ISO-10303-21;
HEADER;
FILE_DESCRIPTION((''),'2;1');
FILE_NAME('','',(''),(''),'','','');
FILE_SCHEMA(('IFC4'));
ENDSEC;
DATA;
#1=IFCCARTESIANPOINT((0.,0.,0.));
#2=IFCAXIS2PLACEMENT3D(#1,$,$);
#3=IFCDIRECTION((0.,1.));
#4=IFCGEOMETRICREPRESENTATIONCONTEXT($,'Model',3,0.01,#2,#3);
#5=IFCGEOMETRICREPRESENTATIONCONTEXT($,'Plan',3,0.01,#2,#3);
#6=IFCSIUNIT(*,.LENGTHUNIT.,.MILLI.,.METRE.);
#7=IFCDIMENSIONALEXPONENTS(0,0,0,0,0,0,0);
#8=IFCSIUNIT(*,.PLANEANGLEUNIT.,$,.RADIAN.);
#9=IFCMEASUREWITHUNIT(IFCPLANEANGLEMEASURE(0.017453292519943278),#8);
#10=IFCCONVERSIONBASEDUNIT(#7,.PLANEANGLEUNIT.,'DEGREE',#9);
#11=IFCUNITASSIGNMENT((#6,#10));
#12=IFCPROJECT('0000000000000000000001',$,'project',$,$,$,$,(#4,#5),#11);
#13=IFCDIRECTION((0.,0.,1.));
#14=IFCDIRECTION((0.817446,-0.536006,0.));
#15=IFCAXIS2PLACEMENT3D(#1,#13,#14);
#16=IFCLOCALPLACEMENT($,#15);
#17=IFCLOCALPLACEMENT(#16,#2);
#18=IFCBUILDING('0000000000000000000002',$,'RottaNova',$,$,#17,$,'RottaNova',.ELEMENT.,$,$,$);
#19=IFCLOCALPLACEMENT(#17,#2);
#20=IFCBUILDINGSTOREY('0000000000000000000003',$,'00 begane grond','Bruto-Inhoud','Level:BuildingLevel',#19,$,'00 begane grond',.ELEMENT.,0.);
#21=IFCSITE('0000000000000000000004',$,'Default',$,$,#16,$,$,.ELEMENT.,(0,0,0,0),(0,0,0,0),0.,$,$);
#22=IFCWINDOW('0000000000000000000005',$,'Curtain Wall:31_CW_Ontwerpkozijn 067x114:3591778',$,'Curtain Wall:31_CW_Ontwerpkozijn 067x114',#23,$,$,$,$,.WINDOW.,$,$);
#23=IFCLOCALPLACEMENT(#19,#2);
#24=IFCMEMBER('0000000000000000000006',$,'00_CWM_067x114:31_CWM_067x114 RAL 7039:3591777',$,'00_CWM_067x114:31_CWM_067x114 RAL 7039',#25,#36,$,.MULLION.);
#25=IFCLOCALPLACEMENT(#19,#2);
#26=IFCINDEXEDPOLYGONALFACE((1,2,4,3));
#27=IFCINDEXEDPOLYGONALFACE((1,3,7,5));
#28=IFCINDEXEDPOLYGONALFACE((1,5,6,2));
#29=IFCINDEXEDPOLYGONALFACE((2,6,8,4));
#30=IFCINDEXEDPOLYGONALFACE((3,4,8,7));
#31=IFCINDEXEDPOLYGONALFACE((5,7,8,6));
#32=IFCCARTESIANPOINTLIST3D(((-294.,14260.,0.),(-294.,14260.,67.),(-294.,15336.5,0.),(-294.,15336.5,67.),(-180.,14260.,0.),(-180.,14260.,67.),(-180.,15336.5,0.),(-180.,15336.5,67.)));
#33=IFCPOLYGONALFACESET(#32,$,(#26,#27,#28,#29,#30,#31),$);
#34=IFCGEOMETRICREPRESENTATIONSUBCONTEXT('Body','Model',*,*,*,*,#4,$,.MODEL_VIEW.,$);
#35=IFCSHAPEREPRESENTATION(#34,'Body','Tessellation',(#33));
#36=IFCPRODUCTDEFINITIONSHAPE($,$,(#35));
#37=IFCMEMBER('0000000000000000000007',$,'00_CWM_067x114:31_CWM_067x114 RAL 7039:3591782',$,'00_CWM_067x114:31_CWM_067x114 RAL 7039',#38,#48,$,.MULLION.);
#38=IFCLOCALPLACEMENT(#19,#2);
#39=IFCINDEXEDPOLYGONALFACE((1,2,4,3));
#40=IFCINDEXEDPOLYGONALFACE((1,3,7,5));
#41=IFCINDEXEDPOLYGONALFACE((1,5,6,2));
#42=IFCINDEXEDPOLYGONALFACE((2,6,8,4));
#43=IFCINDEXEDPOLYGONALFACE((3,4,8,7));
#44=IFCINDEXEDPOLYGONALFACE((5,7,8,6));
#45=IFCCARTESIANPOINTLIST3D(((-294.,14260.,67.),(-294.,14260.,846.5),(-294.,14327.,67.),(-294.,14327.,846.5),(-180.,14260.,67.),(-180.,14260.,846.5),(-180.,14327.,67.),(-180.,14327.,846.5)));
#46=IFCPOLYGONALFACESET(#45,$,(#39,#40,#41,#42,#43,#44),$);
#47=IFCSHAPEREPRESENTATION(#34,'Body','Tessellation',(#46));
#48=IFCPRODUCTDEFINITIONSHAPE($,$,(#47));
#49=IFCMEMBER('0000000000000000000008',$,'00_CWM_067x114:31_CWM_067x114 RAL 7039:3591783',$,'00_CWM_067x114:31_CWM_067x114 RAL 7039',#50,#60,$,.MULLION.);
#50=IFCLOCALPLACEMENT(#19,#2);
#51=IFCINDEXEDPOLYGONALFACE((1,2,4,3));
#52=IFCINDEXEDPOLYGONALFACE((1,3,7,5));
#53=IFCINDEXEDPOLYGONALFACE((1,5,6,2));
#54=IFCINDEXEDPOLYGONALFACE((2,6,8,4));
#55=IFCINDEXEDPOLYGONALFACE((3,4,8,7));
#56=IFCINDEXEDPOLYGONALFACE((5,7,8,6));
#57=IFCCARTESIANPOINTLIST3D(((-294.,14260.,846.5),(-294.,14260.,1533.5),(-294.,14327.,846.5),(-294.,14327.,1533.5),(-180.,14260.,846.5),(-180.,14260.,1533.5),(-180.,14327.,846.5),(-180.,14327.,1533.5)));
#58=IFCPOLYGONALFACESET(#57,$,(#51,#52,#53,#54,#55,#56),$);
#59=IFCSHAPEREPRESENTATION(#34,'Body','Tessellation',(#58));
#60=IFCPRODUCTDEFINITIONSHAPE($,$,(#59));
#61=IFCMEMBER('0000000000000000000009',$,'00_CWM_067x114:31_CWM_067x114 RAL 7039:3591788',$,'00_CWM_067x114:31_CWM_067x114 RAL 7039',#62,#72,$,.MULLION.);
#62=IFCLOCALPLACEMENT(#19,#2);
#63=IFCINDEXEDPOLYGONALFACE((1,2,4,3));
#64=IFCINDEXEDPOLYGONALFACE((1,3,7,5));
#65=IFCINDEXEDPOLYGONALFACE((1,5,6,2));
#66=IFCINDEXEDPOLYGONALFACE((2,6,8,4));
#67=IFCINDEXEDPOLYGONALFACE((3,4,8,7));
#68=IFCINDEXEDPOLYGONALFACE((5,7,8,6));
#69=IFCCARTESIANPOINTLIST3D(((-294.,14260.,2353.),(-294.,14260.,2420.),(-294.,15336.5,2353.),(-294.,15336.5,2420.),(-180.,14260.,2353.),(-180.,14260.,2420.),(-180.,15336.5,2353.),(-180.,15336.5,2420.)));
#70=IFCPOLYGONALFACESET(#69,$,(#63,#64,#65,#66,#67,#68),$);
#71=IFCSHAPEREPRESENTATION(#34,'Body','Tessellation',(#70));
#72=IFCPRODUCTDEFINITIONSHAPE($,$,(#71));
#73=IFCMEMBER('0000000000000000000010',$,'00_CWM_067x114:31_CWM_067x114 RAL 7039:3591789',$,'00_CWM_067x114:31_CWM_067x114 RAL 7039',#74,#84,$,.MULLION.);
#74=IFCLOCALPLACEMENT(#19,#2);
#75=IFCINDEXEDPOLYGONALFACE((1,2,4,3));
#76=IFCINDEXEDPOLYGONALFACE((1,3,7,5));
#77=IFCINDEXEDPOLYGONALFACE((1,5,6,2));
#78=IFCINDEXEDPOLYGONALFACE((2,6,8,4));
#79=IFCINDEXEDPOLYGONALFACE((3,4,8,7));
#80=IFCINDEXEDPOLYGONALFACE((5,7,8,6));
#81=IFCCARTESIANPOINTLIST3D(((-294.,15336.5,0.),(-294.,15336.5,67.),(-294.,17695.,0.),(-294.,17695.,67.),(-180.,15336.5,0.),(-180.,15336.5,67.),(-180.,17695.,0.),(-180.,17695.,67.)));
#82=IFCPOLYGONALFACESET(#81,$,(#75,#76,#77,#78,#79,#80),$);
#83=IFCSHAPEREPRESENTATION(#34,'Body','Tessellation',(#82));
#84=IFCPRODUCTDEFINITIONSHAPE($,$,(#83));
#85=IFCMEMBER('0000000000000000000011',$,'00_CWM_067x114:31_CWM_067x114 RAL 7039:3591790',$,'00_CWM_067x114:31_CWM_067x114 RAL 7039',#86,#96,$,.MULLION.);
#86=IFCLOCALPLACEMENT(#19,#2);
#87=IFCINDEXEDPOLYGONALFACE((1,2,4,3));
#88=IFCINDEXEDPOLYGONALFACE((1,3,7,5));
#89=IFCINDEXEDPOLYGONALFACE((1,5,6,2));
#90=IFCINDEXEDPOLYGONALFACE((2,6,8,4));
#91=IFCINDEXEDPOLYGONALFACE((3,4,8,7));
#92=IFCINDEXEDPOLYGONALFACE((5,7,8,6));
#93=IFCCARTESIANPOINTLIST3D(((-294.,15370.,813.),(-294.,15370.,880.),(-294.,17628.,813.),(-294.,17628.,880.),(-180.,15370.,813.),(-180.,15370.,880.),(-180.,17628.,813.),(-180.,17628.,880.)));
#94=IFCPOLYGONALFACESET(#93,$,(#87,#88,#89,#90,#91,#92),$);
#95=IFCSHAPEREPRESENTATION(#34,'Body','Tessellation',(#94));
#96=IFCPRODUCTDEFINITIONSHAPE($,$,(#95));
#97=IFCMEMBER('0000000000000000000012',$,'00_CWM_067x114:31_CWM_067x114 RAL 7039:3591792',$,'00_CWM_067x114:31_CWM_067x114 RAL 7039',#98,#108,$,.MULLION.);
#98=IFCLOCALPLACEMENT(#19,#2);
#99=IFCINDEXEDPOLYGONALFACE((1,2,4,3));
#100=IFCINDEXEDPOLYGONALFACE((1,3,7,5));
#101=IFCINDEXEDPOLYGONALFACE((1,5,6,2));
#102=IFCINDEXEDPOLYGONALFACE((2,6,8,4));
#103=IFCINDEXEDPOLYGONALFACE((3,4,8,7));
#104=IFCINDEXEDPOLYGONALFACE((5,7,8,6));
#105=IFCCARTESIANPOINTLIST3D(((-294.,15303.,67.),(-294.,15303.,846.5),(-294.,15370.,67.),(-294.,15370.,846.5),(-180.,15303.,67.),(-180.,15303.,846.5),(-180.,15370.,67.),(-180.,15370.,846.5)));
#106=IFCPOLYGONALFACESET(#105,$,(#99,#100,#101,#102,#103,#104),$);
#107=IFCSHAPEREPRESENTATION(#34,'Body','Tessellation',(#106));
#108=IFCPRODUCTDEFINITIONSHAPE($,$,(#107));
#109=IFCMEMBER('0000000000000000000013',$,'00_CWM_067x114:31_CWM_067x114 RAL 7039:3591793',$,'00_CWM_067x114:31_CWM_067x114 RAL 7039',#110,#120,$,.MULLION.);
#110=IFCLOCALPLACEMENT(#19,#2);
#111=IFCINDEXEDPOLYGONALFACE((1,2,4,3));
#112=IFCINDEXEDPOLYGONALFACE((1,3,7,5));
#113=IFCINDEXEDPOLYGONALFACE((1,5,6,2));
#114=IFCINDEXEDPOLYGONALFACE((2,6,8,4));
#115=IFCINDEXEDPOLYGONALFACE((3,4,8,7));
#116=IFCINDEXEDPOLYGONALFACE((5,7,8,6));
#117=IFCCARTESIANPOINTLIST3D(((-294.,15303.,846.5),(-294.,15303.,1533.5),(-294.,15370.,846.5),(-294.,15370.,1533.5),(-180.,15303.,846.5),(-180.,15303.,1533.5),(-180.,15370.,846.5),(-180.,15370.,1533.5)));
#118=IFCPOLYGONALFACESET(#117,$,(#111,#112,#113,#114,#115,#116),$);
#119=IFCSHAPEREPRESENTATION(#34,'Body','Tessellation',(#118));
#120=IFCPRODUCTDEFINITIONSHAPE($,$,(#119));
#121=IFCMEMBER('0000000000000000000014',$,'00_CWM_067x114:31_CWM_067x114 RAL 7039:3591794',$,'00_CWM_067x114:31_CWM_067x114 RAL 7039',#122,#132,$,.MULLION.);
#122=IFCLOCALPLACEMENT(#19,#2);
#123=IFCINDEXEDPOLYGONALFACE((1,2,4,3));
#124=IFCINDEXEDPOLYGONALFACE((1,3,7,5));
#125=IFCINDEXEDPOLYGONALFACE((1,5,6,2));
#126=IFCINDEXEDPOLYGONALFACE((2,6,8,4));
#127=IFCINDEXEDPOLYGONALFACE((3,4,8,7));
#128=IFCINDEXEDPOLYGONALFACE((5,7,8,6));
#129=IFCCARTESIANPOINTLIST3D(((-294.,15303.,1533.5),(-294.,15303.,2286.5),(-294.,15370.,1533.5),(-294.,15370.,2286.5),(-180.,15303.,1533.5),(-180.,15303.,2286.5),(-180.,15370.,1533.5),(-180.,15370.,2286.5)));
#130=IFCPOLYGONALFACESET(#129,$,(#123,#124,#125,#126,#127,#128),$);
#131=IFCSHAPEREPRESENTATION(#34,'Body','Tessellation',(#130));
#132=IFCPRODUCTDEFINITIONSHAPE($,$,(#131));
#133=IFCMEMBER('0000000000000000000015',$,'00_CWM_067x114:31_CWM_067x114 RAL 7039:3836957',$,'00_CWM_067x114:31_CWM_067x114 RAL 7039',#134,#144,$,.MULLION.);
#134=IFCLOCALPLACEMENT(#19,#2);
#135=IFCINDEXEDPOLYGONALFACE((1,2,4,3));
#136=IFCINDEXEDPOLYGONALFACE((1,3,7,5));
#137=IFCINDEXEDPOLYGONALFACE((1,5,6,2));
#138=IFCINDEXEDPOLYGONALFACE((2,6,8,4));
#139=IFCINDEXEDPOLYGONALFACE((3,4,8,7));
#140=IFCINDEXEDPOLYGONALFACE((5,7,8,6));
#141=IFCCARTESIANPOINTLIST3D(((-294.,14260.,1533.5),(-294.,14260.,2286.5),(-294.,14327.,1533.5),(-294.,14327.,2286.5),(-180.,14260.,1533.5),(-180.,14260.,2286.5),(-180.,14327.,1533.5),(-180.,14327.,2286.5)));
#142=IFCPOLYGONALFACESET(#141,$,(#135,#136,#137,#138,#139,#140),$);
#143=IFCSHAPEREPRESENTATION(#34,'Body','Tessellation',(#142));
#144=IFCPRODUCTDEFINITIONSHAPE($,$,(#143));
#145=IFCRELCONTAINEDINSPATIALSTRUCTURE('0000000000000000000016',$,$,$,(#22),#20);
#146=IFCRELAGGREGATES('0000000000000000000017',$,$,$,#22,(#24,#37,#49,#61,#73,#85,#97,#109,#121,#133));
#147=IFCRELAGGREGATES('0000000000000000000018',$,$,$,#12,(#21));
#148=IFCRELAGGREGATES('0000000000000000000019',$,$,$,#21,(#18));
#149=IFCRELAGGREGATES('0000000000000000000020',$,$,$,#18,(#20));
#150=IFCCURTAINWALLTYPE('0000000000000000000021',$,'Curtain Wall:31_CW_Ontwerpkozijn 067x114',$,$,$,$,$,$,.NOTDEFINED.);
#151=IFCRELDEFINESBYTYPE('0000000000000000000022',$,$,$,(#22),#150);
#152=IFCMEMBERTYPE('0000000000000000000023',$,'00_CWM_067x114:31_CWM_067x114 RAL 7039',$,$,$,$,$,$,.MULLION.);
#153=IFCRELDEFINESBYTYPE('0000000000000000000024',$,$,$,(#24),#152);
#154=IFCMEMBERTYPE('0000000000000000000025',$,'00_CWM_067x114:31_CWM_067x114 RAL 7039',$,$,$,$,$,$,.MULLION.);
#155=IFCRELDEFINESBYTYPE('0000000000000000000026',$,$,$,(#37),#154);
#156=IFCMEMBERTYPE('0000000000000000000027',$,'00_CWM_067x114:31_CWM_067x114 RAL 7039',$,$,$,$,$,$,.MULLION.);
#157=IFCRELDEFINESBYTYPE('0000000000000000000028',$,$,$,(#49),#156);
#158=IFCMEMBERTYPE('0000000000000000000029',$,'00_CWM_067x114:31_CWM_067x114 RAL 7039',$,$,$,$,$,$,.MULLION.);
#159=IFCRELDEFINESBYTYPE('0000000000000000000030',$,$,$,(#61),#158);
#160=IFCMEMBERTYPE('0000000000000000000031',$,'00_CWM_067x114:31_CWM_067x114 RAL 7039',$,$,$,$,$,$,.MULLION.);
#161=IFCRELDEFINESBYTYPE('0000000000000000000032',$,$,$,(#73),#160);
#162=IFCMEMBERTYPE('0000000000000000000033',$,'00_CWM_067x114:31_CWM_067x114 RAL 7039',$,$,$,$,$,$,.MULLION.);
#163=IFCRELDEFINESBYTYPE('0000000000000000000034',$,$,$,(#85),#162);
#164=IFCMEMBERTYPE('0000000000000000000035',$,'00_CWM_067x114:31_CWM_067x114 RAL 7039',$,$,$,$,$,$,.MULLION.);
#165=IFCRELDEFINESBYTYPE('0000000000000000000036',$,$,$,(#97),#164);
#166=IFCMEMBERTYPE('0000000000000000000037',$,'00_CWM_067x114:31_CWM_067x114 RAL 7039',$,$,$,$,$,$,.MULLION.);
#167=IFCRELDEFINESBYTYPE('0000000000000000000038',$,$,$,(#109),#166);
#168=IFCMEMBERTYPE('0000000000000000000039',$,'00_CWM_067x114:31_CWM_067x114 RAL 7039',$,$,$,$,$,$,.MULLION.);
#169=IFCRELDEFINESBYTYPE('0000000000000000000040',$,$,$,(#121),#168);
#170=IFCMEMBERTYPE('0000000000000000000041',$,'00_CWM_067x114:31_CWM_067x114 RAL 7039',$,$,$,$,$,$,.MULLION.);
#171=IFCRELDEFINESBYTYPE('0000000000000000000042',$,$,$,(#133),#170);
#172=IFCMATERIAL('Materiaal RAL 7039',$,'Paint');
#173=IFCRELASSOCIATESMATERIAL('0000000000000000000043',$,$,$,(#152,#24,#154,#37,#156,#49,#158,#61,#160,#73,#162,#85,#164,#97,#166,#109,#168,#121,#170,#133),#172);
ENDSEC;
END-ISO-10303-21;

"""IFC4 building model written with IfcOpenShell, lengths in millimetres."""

from ifc_helpers import new_model, entity, si_unit, converted_unit, direction, frame, origin, place, context, subcontext, project, spatial, indexed_curve, outline, extrude, source, transform, mapped, material, type_object, type_shapes, element, aggregate, save


model = new_model("IFC4")

# Units and contexts
model_context = context("Model", 3, precision=0.01, world=origin(), true_north=direction((0.0, 1.0)))
plan_context = context("Plan", 3, precision=0.01, world=origin(), true_north=direction((0.0, 1.0)))
body_context = subcontext(model_context, "Body", "Model", "MODEL_VIEW")
ifc_project = project(units=[si_unit("LENGTHUNIT", "METRE", prefix="MILLI"), converted_unit("PLANEANGLEUNIT", "DEGREE", entity("IfcPlaneAngleMeasure", 0.017453292519943278), si_unit("PLANEANGLEUNIT", "RADIAN"), dimensions=[0, 0, 0, 0, 0, 0, 0])], contexts=[model_context, plan_context])

# Site, building, storey
site_placement = place(None, frame((0.0, 0.0, 0.0), z_axis=(0.0, 0.0, 1.0), x_axis=(0.817446, -0.536006, 0.0)))
site = spatial("IfcSite", under=ifc_project, at=site_placement, Name="Default", CompositionType="ELEMENT", RefLatitude=(0, 0, 0, 0), RefLongitude=(0, 0, 0, 0), RefElevation=0.0)
building_placement = place(site_placement, origin())
building = spatial("IfcBuilding", under=site, at=building_placement, Name="RottaNova", LongName="RottaNova", CompositionType="ELEMENT")
storey_placement = place(building_placement, origin())
storey = spatial("IfcBuildingStorey", under=building, at=storey_placement, Name="00 begane grond", Description="Bruto-Inhoud", ObjectType="Level:BuildingLevel", LongName="00 begane grond", CompositionType="ELEMENT", Elevation=0.0)

# Window, members
curtain_wall_type = type_object("IfcCurtainWallType", Name="Curtain Wall:31_CW_Ontwerpkozijn 067x114", PredefinedType="NOTDEFINED")
window_1_placement = place(storey_placement, origin())
window_1 = element("IfcWindow", 1, at=window_1_placement, inside=storey, type_object=curtain_wall_type, Name="Curtain Wall:31_CW_Ontwerpkozijn 067x114:3591778", ObjectType="Curtain Wall:31_CW_Ontwerpkozijn 067x114", PredefinedType="WINDOW")
ifc_material_1 = material(Name="Materiaal RAL 7039", Category="Paint")
member_type_1 = type_object("IfcMemberType", Name="00_CWM_067x114:31_CWM_067x114 RAL 7039", PredefinedType="MULLION", material=ifc_material_1)
shared_shape_1 = source(origin(), body_context, "Body", "SweptSolid", [
    extrude(outline(indexed_curve([(-33.5, -57.0), (33.5, -57.0), (33.5, 57.0), (-33.5, 57.0), (-33.5, -57.0)], self_intersect=False)), frame((-33.5, -57.0, -1076.5), z_axis=(0.0, 0.0, 1.0), x_axis=(-1.0, 0.0, 0.0)), (0.0, 0.0, 1.0), 1076.5),
])
type_shapes(member_type_1, [shared_shape_1])
member_1_placement = place(window_1_placement, frame((-180.0, 14260.0, 0.0), z_axis=(0.0, -1.0, 0.0), x_axis=(0.0, 0.0, -1.0)))
member_1 = element("IfcMember", 2, at=member_1_placement, type_object=member_type_1, material=ifc_material_1, Name="00_CWM_067x114:31_CWM_067x114 RAL 7039:3591777", ObjectType="00_CWM_067x114:31_CWM_067x114 RAL 7039", PredefinedType="MULLION", context=body_context, shape_type="MappedRepresentation", body=[
    mapped(shared_shape_1, transform((0.0, 0.0, 0.0), scale=1.0)),
])
member_type_2 = type_object("IfcMemberType", Name="00_CWM_067x114:31_CWM_067x114 RAL 7039", PredefinedType="MULLION", material=ifc_material_1)
shared_shape_2 = source(origin(), body_context, "Body", "SweptSolid", [
    extrude(outline(indexed_curve([(-33.5, -57.0), (33.5, -57.0), (33.5, 57.0), (-33.5, 57.0), (-33.5, -57.0)], self_intersect=False)), frame((-33.5, -57.0, -779.5), z_axis=(0.0, 0.0, 1.0), x_axis=(-1.0, 0.0, 0.0)), (0.0, 0.0, 1.0), 779.5),
])
type_shapes(member_type_2, [shared_shape_2])
member_2_placement = place(window_1_placement, frame((-180.0, 14260.0, 846.5), z_axis=(0.0, 0.0, 1.0), x_axis=(0.0, -1.0, 0.0)))
member_2 = element("IfcMember", 3, at=member_2_placement, type_object=member_type_2, material=ifc_material_1, Name="00_CWM_067x114:31_CWM_067x114 RAL 7039:3591782", ObjectType="00_CWM_067x114:31_CWM_067x114 RAL 7039", PredefinedType="MULLION", context=body_context, shape_type="MappedRepresentation", body=[
    mapped(shared_shape_2, transform((0.0, 0.0, 0.0), scale=1.0)),
])
member_type_3 = type_object("IfcMemberType", Name="00_CWM_067x114:31_CWM_067x114 RAL 7039", PredefinedType="MULLION", material=ifc_material_1)
shared_shape_3 = source(origin(), body_context, "Body", "SweptSolid", [
    extrude(outline(indexed_curve([(-33.5, -57.0), (33.5, -57.0), (33.5, 57.0), (-33.5, 57.0), (-33.5, -57.0)], self_intersect=False)), frame((-33.5, -57.0, -687.0), z_axis=(0.0, 0.0, 1.0), x_axis=(-1.0, 0.0, 0.0)), (0.0, 0.0, 1.0), 687.0),
])
type_shapes(member_type_3, [shared_shape_3])
member_3_placement = place(window_1_placement, frame((-180.0, 14260.0, 1533.5), z_axis=(0.0, 0.0, 1.0), x_axis=(0.0, -1.0, 0.0)))
member_3 = element("IfcMember", 4, at=member_3_placement, type_object=member_type_3, material=ifc_material_1, Name="00_CWM_067x114:31_CWM_067x114 RAL 7039:3591783", ObjectType="00_CWM_067x114:31_CWM_067x114 RAL 7039", PredefinedType="MULLION", context=body_context, shape_type="MappedRepresentation", body=[
    mapped(shared_shape_3, transform((0.0, 0.0, 0.0), scale=1.0)),
])
member_type_4 = type_object("IfcMemberType", Name="00_CWM_067x114:31_CWM_067x114 RAL 7039", PredefinedType="MULLION", material=ifc_material_1)
shared_shape_4 = source(origin(), body_context, "Body", "SweptSolid", [
    extrude(outline(indexed_curve([(-33.5, -57.0), (33.5, -57.0), (33.5, 57.0), (-33.5, 57.0), (-33.5, -57.0)], self_intersect=False)), frame((-33.5, -57.0, -1076.5), z_axis=(0.0, 0.0, 1.0), x_axis=(-1.0, 0.0, 0.0)), (0.0, 0.0, 1.0), 1076.5),
])
type_shapes(member_type_4, [shared_shape_4])
member_4_placement = place(window_1_placement, frame((-180.0, 15336.5, 2420.0), z_axis=(0.0, 1.0, 0.0), x_axis=(0.0, 0.0, 1.0)))
member_4 = element("IfcMember", 5, at=member_4_placement, type_object=member_type_4, material=ifc_material_1, Name="00_CWM_067x114:31_CWM_067x114 RAL 7039:3591788", ObjectType="00_CWM_067x114:31_CWM_067x114 RAL 7039", PredefinedType="MULLION", context=body_context, shape_type="MappedRepresentation", body=[
    mapped(shared_shape_4, transform((0.0, 0.0, 0.0), scale=1.0)),
])
member_type_5 = type_object("IfcMemberType", Name="00_CWM_067x114:31_CWM_067x114 RAL 7039", PredefinedType="MULLION", material=ifc_material_1)
shared_shape_5 = source(origin(), body_context, "Body", "SweptSolid", [
    extrude(outline(indexed_curve([(-33.5, -57.0), (33.5, -57.0), (33.5, 57.0), (-33.5, 57.0), (-33.5, -57.0)], self_intersect=False)), frame((-33.5, -57.0, -2358.5), z_axis=(0.0, 0.0, 1.0), x_axis=(-1.0, 0.0, 0.0)), (0.0, 0.0, 1.0), 2358.5),
])
type_shapes(member_type_5, [shared_shape_5])
member_5_placement = place(window_1_placement, frame((-180.0, 15336.5, 0.0), z_axis=(0.0, -1.0, 0.0), x_axis=(0.0, 0.0, -1.0)))
member_5 = element("IfcMember", 6, at=member_5_placement, type_object=member_type_5, material=ifc_material_1, Name="00_CWM_067x114:31_CWM_067x114 RAL 7039:3591789", ObjectType="00_CWM_067x114:31_CWM_067x114 RAL 7039", PredefinedType="MULLION", context=body_context, shape_type="MappedRepresentation", body=[
    mapped(shared_shape_5, transform((0.0, 0.0, 0.0), scale=1.0)),
])
member_type_6 = type_object("IfcMemberType", Name="00_CWM_067x114:31_CWM_067x114 RAL 7039", PredefinedType="MULLION", material=ifc_material_1)
shared_shape_6 = source(origin(), body_context, "Body", "SweptSolid", [
    extrude(outline(indexed_curve([(-33.5, -57.0), (33.5, -57.0), (33.5, 57.0), (-33.5, 57.0), (-33.5, -57.0)], self_intersect=False)), frame((0.0, -57.0, -2258.0), z_axis=(0.0, 0.0, 1.0), x_axis=(-1.0, 0.0, 0.0)), (0.0, 0.0, 1.0), 2258.0),
])
type_shapes(member_type_6, [shared_shape_6])
member_6_placement = place(window_1_placement, frame((-180.0, 17628.0, 846.5), z_axis=(0.0, 1.0, 0.0), x_axis=(0.0, 0.0, 1.0)))
member_6 = element("IfcMember", 7, at=member_6_placement, type_object=member_type_6, material=ifc_material_1, Name="00_CWM_067x114:31_CWM_067x114 RAL 7039:3591790", ObjectType="00_CWM_067x114:31_CWM_067x114 RAL 7039", PredefinedType="MULLION", context=body_context, shape_type="MappedRepresentation", body=[
    mapped(shared_shape_6, transform((0.0, 0.0, 0.0), scale=1.0)),
])
member_type_7 = type_object("IfcMemberType", Name="00_CWM_067x114:31_CWM_067x114 RAL 7039", PredefinedType="MULLION", material=ifc_material_1)
shared_shape_7 = source(origin(), body_context, "Body", "SweptSolid", [
    extrude(outline(indexed_curve([(-33.5, -57.0), (33.5, -57.0), (33.5, 57.0), (-33.5, 57.0), (-33.5, -57.0)], self_intersect=False)), frame((0.0, -57.0, -779.5), z_axis=(0.0, 0.0, 1.0), x_axis=(-1.0, 0.0, 0.0)), (0.0, 0.0, 1.0), 779.5),
])
type_shapes(member_type_7, [shared_shape_7])
member_7_placement = place(window_1_placement, frame((-180.0, 15336.5, 67.0), z_axis=(0.0, 0.0, -1.0), x_axis=(0.0, 1.0, 0.0)))
member_7 = element("IfcMember", 8, at=member_7_placement, type_object=member_type_7, material=ifc_material_1, Name="00_CWM_067x114:31_CWM_067x114 RAL 7039:3591792", ObjectType="00_CWM_067x114:31_CWM_067x114 RAL 7039", PredefinedType="MULLION", context=body_context, shape_type="MappedRepresentation", body=[
    mapped(shared_shape_7, transform((0.0, 0.0, 0.0), scale=1.0)),
])
member_type_8 = type_object("IfcMemberType", Name="00_CWM_067x114:31_CWM_067x114 RAL 7039", PredefinedType="MULLION", material=ifc_material_1)
shared_shape_8 = source(origin(), body_context, "Body", "SweptSolid", [
    extrude(outline(indexed_curve([(-33.5, -57.0), (33.5, -57.0), (33.5, 57.0), (-33.5, 57.0), (-33.5, -57.0)], self_intersect=False)), frame((0.0, -57.0, -687.0), z_axis=(0.0, 0.0, 1.0), x_axis=(-1.0, 0.0, 0.0)), (0.0, 0.0, 1.0), 687.0),
])
type_shapes(member_type_8, [shared_shape_8])
member_8_placement = place(window_1_placement, frame((-180.0, 15336.5, 846.5), z_axis=(0.0, 0.0, -1.0), x_axis=(0.0, 1.0, 0.0)))
member_8 = element("IfcMember", 9, at=member_8_placement, type_object=member_type_8, material=ifc_material_1, Name="00_CWM_067x114:31_CWM_067x114 RAL 7039:3591793", ObjectType="00_CWM_067x114:31_CWM_067x114 RAL 7039", PredefinedType="MULLION", context=body_context, shape_type="MappedRepresentation", body=[
    mapped(shared_shape_8, transform((0.0, 0.0, 0.0), scale=1.0)),
])
member_type_9 = type_object("IfcMemberType", Name="00_CWM_067x114:31_CWM_067x114 RAL 7039", PredefinedType="MULLION", material=ifc_material_1)
shared_shape_9 = source(origin(), body_context, "Body", "SweptSolid", [
    extrude(outline(indexed_curve([(-33.5, -57.0), (33.5, -57.0), (33.5, 57.0), (-33.5, 57.0), (-33.5, -57.0)], self_intersect=False)), frame((0.0, -57.0, -753.0), z_axis=(0.0, 0.0, 1.0), x_axis=(-1.0, 0.0, 0.0)), (0.0, 0.0, 1.0), 753.0),
])
type_shapes(member_type_9, [shared_shape_9])
member_9_placement = place(window_1_placement, frame((-180.0, 15336.5, 1533.5), z_axis=(0.0, 0.0, -1.0), x_axis=(0.0, 1.0, 0.0)))
member_9 = element("IfcMember", 10, at=member_9_placement, type_object=member_type_9, material=ifc_material_1, Name="00_CWM_067x114:31_CWM_067x114 RAL 7039:3591794", ObjectType="00_CWM_067x114:31_CWM_067x114 RAL 7039", PredefinedType="MULLION", context=body_context, shape_type="MappedRepresentation", body=[
    mapped(shared_shape_9, transform((0.0, 0.0, 0.0), scale=1.0)),
])
member_type_10 = type_object("IfcMemberType", Name="00_CWM_067x114:31_CWM_067x114 RAL 7039", PredefinedType="MULLION", material=ifc_material_1)
shared_shape_10 = source(origin(), body_context, "Body", "SweptSolid", [
    extrude(outline(indexed_curve([(-33.5, -57.0), (33.5, -57.0), (33.5, 57.0), (-33.5, 57.0), (-33.5, -57.0)], self_intersect=False)), frame((-33.5, -57.0, -753.0), z_axis=(0.0, 0.0, 1.0), x_axis=(-1.0, 0.0, 0.0)), (0.0, 0.0, 1.0), 753.0),
])
type_shapes(member_type_10, [shared_shape_10])
member_10_placement = place(window_1_placement, frame((-180.0, 14260.0, 2286.5), z_axis=(0.0, 0.0, 1.0), x_axis=(0.0, -1.0, 0.0)))
member_10 = element("IfcMember", 11, at=member_10_placement, type_object=member_type_10, material=ifc_material_1, Name="00_CWM_067x114:31_CWM_067x114 RAL 7039:3836957", ObjectType="00_CWM_067x114:31_CWM_067x114 RAL 7039", PredefinedType="MULLION", context=body_context, shape_type="MappedRepresentation", body=[
    mapped(shared_shape_10, transform((0.0, 0.0, 0.0), scale=1.0)),
])

aggregate(window_1, [member_1, member_2, member_3, member_4, member_5, member_6, member_7, member_8, member_9, member_10])

save(model, "model.ifc")
